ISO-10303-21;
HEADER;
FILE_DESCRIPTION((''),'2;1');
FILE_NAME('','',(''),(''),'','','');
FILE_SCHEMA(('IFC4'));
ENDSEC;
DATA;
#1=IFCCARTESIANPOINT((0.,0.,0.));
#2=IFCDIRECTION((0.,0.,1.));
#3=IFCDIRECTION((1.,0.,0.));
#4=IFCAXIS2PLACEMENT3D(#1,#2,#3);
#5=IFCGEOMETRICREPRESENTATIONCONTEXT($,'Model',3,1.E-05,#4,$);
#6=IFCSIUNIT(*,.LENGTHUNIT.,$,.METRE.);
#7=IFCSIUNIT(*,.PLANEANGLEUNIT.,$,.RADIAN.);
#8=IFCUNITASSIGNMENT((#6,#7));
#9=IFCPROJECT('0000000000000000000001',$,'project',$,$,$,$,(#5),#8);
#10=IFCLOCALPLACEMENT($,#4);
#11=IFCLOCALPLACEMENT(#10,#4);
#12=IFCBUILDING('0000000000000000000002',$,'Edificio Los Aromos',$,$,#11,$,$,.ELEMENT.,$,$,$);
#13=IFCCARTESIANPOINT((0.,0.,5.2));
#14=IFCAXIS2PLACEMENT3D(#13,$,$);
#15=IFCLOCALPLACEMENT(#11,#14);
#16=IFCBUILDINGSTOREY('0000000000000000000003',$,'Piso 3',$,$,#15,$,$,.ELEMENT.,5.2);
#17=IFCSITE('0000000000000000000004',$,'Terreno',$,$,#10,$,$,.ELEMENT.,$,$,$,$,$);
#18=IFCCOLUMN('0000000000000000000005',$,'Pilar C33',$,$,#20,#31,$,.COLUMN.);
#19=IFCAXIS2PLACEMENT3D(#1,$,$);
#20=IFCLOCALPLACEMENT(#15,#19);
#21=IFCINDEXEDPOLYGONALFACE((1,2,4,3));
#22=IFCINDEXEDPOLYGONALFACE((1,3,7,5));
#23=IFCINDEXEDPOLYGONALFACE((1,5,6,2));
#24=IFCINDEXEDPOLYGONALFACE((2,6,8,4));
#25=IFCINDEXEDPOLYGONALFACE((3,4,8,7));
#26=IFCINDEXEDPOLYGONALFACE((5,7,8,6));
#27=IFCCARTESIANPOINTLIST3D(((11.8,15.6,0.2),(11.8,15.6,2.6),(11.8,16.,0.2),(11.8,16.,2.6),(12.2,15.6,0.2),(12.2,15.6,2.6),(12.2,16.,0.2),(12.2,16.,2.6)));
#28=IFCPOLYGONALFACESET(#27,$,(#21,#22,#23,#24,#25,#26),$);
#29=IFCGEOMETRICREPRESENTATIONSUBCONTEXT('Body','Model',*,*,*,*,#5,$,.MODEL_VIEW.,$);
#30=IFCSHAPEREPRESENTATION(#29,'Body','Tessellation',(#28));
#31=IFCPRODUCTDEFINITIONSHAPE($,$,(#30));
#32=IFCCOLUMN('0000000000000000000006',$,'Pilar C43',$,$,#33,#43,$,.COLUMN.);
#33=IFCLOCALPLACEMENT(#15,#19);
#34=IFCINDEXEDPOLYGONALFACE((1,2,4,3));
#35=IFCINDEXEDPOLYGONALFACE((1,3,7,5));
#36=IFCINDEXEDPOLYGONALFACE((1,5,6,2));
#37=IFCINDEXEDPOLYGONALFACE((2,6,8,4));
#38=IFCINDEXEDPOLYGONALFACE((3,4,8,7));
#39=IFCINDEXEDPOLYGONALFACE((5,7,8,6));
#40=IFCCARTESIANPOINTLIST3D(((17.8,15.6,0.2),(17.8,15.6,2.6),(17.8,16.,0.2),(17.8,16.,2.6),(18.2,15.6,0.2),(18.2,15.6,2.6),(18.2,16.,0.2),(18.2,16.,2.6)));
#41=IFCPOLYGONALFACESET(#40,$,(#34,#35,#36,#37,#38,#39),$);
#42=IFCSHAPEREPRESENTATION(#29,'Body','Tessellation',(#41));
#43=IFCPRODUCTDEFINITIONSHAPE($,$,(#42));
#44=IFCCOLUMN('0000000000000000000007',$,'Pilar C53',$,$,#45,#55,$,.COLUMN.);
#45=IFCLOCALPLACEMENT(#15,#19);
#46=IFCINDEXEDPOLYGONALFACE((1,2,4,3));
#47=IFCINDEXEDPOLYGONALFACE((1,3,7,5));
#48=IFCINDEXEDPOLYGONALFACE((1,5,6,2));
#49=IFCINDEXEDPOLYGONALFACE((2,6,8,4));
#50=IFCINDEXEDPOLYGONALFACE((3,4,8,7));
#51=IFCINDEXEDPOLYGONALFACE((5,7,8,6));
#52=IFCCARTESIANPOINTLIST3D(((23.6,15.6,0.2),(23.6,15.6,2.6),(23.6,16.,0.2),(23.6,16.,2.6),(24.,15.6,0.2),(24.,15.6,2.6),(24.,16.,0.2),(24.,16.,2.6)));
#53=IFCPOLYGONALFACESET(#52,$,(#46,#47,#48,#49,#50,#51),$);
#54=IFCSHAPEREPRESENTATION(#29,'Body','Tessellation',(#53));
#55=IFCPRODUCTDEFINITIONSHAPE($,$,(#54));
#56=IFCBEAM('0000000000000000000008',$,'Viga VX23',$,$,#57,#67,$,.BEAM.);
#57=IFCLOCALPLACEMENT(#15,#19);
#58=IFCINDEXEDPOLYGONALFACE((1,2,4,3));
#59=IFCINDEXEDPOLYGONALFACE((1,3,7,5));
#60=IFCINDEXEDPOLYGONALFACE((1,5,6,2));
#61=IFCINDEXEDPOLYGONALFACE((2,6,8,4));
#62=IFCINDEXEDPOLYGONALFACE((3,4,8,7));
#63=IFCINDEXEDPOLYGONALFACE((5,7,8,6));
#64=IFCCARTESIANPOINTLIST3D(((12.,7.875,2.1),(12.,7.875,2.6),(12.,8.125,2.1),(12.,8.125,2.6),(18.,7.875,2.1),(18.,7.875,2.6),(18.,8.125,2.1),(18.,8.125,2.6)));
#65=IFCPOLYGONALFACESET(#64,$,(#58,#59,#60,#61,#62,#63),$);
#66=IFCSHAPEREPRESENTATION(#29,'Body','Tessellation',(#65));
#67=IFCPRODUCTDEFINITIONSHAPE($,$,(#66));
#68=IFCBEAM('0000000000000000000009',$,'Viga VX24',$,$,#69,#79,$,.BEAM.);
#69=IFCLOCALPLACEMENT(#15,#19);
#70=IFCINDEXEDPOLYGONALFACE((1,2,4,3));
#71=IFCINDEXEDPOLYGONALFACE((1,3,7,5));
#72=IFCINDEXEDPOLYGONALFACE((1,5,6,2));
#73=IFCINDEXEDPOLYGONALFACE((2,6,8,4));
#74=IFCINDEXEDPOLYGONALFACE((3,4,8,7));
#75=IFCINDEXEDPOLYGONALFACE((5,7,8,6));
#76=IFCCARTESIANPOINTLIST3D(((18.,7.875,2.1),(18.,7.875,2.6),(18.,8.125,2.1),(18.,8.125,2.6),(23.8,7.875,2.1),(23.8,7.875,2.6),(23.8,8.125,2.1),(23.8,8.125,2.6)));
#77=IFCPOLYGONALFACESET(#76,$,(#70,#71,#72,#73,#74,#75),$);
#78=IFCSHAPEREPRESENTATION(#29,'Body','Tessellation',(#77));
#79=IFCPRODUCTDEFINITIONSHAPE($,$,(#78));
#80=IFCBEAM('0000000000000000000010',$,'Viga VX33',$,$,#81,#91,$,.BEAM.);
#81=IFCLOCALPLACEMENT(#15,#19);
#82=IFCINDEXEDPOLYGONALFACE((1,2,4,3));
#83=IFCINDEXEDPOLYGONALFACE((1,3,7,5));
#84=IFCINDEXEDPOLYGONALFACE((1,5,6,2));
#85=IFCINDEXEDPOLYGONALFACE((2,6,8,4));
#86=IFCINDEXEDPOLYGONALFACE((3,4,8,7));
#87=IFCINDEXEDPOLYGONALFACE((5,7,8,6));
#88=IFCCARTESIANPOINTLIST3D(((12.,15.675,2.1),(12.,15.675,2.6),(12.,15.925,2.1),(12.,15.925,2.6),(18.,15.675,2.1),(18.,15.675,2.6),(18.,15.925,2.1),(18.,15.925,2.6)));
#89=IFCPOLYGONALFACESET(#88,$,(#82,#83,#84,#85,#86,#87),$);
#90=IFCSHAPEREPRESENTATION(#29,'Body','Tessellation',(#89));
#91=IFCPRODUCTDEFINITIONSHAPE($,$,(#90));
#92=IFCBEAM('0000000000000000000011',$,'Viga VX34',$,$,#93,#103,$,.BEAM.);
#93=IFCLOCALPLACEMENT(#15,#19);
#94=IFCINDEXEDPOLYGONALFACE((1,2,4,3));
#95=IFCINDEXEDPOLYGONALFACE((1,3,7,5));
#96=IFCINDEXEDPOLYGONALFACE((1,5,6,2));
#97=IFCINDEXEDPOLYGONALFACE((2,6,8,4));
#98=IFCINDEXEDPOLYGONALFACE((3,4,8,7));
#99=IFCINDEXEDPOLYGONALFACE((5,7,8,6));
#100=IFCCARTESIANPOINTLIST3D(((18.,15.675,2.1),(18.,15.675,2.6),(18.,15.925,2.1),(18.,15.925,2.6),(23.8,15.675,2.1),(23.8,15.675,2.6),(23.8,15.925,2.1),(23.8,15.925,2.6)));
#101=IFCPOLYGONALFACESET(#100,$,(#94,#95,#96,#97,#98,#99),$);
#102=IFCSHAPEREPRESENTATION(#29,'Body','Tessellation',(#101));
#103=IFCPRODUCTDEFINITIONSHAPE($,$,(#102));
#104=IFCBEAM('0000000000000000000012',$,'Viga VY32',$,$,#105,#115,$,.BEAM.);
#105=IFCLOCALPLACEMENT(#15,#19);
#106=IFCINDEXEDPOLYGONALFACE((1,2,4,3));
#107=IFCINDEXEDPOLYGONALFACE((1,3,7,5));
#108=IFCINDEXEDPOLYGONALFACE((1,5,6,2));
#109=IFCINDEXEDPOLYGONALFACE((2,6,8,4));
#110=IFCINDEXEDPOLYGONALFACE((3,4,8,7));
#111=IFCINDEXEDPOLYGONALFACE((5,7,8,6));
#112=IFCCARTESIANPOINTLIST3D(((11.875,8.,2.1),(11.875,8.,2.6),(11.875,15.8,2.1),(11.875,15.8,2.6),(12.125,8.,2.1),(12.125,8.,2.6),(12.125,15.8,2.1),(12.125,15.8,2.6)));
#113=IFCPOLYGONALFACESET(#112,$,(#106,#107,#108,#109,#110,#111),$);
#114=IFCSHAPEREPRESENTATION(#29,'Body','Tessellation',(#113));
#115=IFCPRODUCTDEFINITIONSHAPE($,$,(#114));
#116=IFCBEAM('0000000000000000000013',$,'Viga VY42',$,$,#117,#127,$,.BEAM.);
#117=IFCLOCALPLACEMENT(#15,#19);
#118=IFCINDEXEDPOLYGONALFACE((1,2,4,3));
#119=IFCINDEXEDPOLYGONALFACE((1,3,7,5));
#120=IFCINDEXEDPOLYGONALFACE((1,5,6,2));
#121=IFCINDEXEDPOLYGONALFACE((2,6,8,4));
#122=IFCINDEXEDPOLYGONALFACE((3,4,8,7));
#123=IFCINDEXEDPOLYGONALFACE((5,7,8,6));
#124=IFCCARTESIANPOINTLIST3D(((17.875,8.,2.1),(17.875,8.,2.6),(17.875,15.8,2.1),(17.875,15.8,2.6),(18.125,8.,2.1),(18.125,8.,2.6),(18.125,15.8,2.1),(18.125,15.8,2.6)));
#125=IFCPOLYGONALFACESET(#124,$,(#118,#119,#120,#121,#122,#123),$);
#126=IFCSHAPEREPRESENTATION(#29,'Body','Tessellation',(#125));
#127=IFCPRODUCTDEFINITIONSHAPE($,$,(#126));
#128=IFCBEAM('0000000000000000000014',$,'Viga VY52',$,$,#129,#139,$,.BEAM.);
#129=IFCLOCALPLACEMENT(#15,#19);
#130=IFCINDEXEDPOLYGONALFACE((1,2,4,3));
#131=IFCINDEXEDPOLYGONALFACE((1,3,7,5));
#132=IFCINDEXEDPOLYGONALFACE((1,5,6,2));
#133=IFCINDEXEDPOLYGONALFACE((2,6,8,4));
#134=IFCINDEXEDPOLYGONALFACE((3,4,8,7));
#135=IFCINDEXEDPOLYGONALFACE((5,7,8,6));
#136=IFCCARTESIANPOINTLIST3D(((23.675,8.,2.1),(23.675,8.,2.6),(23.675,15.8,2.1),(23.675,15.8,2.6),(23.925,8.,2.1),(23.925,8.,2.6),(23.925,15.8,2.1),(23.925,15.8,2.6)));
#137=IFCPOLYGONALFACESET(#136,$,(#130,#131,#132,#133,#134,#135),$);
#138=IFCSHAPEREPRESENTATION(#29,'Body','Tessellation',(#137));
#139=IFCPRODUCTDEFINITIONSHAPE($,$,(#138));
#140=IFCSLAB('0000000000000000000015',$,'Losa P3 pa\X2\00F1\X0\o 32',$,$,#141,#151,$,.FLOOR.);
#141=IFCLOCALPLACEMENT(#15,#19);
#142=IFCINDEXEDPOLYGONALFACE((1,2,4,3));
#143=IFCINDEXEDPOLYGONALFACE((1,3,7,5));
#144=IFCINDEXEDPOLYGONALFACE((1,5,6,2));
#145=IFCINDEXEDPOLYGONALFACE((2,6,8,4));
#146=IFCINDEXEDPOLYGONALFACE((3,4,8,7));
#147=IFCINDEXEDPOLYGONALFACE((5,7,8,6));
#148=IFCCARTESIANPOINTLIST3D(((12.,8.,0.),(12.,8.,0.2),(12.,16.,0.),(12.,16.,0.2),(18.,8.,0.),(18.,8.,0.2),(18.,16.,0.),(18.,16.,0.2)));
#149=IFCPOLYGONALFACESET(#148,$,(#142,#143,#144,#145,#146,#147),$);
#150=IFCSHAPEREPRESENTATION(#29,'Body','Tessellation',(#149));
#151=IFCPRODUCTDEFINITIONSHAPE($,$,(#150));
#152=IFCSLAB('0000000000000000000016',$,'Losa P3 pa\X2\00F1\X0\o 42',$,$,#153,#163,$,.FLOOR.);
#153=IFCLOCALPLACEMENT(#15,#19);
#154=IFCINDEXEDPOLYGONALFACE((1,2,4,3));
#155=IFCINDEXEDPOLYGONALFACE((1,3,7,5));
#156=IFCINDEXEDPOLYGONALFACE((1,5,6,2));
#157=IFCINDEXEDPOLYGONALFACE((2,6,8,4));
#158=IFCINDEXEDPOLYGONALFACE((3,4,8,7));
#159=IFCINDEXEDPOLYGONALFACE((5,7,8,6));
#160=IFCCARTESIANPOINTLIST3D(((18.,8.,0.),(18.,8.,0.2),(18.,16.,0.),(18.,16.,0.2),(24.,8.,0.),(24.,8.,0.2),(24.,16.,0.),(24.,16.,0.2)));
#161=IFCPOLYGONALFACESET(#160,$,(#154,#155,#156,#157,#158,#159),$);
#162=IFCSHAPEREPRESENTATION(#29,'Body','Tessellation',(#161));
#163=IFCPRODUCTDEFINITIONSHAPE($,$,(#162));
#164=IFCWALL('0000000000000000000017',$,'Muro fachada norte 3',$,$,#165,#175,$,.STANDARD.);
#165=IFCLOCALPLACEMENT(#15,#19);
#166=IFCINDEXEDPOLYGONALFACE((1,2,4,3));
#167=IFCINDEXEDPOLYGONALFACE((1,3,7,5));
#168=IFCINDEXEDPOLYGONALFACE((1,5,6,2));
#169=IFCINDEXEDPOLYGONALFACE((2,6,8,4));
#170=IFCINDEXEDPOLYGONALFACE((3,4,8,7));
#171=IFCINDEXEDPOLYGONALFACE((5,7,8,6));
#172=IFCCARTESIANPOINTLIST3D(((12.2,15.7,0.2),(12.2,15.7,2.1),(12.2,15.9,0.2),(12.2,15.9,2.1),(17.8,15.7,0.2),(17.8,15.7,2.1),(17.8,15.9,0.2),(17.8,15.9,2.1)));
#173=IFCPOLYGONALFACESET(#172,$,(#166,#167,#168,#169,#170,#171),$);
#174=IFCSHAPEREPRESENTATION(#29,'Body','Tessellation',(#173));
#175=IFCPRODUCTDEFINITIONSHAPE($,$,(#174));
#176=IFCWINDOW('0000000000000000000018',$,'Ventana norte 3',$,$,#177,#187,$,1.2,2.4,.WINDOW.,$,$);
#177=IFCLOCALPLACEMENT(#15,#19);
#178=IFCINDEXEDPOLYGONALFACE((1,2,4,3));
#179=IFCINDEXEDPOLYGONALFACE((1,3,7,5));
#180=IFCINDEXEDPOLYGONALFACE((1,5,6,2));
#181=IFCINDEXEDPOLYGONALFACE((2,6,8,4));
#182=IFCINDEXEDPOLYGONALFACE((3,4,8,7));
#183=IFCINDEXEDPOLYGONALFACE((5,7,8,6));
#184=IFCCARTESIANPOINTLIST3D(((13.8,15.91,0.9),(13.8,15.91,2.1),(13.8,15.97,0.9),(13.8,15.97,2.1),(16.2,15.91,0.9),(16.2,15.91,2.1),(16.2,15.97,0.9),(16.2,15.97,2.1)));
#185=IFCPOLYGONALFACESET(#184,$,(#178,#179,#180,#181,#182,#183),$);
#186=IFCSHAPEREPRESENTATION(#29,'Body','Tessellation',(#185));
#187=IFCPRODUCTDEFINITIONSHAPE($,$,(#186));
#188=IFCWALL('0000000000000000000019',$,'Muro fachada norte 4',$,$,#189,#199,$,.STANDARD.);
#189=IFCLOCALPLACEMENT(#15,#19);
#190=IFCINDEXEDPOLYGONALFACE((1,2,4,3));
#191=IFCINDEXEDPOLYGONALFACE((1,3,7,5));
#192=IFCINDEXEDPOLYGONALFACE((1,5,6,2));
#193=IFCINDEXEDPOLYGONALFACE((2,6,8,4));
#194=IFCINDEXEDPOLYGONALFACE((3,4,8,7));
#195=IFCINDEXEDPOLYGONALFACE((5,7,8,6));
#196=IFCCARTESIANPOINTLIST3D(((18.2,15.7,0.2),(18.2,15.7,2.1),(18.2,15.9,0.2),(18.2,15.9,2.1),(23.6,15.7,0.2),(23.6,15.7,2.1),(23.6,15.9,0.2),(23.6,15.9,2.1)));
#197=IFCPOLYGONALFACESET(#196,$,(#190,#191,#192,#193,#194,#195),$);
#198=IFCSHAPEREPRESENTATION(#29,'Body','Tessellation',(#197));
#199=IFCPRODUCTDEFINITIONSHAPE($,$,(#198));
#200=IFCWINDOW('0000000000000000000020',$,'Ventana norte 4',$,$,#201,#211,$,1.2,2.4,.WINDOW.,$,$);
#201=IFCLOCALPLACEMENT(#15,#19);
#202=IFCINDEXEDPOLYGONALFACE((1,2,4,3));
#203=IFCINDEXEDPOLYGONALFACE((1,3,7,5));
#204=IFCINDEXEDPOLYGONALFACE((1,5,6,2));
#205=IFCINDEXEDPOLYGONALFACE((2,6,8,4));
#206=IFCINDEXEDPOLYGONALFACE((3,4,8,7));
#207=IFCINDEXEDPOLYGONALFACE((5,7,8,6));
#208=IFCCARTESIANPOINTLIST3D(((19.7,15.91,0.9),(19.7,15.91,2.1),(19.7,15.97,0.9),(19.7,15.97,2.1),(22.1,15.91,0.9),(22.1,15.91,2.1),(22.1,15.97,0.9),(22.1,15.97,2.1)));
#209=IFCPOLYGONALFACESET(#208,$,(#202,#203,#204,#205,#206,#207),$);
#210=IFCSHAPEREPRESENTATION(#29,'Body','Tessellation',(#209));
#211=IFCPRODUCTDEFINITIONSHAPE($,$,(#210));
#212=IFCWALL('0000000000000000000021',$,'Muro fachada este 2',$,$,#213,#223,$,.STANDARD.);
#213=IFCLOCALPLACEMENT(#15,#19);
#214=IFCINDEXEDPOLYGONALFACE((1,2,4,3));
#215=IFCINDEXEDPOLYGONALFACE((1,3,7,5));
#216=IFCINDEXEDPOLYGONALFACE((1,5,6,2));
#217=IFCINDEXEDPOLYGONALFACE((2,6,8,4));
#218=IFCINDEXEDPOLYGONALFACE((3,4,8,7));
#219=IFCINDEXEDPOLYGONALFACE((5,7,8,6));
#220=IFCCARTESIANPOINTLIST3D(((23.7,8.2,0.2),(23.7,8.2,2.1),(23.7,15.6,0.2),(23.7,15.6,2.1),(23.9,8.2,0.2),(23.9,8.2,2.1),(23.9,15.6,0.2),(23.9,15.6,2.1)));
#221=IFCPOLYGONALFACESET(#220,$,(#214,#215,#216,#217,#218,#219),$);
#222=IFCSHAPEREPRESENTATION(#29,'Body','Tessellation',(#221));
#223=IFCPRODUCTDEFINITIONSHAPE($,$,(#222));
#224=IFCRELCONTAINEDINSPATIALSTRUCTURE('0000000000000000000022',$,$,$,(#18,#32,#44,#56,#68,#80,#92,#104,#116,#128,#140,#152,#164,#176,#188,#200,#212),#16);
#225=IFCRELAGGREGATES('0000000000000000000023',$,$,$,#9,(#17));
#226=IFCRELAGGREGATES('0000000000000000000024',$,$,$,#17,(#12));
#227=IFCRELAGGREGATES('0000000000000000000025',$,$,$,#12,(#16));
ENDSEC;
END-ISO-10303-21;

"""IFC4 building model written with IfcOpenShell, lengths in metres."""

from ifc_helpers import new_model, si_unit, frame, frame_2d, origin_with_axes, place, context, subcontext, project, spatial, rectangle, extrude, element, save


model = new_model("IFC4")

# Units and contexts
model_context = context("Model", 3, precision=1e-05, world=origin_with_axes())
body_context = subcontext(model_context, "Body", "Model", "MODEL_VIEW")
ifc_project = project(units=[si_unit("LENGTHUNIT", "METRE"), si_unit("PLANEANGLEUNIT", "RADIAN")], contexts=[model_context])

# Site, building, storey
site_placement = place(None, origin_with_axes())
site = spatial("IfcSite", under=ifc_project, at=site_placement, Name="Terreno", CompositionType="ELEMENT")
building_placement = place(site_placement, origin_with_axes())
building = spatial("IfcBuilding", under=site, at=building_placement, Name="Edificio Los Aromos", CompositionType="ELEMENT")
storey_placement = place(building_placement, frame((0.0, 0.0, 5.2)))
storey = spatial("IfcBuildingStorey", under=building, at=storey_placement, Name="Piso 3", CompositionType="ELEMENT", Elevation=5.2)

# Columns
for number, where, name in (
    (1, (11.8, 15.6, 0.2), "Pilar C33"),
    (2, (17.8, 15.6, 0.2), "Pilar C43"),
    (3, (23.6, 15.6, 0.2), "Pilar C53"),
):
    element("IfcColumn", number, at=place(storey_placement, frame(where)), inside=storey, Name=name, PredefinedType="COLUMN", context=body_context, shape_type="SweptSolid", body=[
        extrude(rectangle(XDim=0.4, YDim=0.4, at=frame_2d((0.2, 0.2))), origin_with_axes(), (0.0, 0.0, 1.0), 2.4),
    ])

# Beams
beam_1_placement = place(storey_placement, frame((12.0, 7.875, 2.1)))
element("IfcBeam", 4, at=beam_1_placement, inside=storey, Name="Viga VX23", PredefinedType="BEAM", context=body_context, shape_type="SweptSolid", body=[
    extrude(rectangle(XDim=6.0, YDim=0.25, at=frame_2d((3.0, 0.125))), origin_with_axes(), (0.0, 0.0, 1.0), 0.5),
])
beam_2_placement = place(storey_placement, frame((18.0, 7.875, 2.1)))
element("IfcBeam", 5, at=beam_2_placement, inside=storey, Name="Viga VX24", PredefinedType="BEAM", context=body_context, shape_type="SweptSolid", body=[
    extrude(rectangle(XDim=5.8, YDim=0.25, at=frame_2d((2.9, 0.125))), origin_with_axes(), (0.0, 0.0, 1.0), 0.5),
])
beam_3_placement = place(storey_placement, frame((12.0, 15.675, 2.1)))
element("IfcBeam", 6, at=beam_3_placement, inside=storey, Name="Viga VX33", PredefinedType="BEAM", context=body_context, shape_type="SweptSolid", body=[
    extrude(rectangle(XDim=6.0, YDim=0.25, at=frame_2d((3.0, 0.125))), origin_with_axes(), (0.0, 0.0, 1.0), 0.5),
])
beam_4_placement = place(storey_placement, frame((18.0, 15.675, 2.1)))
element("IfcBeam", 7, at=beam_4_placement, inside=storey, Name="Viga VX34", PredefinedType="BEAM", context=body_context, shape_type="SweptSolid", body=[
    extrude(rectangle(XDim=5.8, YDim=0.25, at=frame_2d((2.9, 0.125))), origin_with_axes(), (0.0, 0.0, 1.0), 0.5),
])
for number, where, name in (
    (8, (11.875, 8.0, 2.1), "Viga VY32"),
    (9, (17.875, 8.0, 2.1), "Viga VY42"),
    (10, (23.675, 8.0, 2.1), "Viga VY52"),
):
    element("IfcBeam", number, at=place(storey_placement, frame(where)), inside=storey, Name=name, PredefinedType="BEAM", context=body_context, shape_type="SweptSolid", body=[
        extrude(rectangle(XDim=0.25, YDim=7.8, at=frame_2d((0.125, 3.9))), origin_with_axes(), (0.0, 0.0, 1.0), 0.5),
    ])

# Slabs
for number, where, name in (
    (11, (12.0, 8.0, 0.0), "Losa P3 paño 32"),
    (12, (18.0, 8.0, 0.0), "Losa P3 paño 42"),
):
    element("IfcSlab", number, at=place(storey_placement, frame(where)), inside=storey, Name=name, PredefinedType="FLOOR", context=body_context, shape_type="SweptSolid", body=[
        extrude(rectangle(XDim=6.0, YDim=8.0, at=frame_2d((3.0, 4.0))), origin_with_axes(), (0.0, 0.0, 1.0), 0.2),
    ])

# Wall
wall_1_placement = place(storey_placement, frame((12.2, 15.7, 0.2)))
element("IfcWall", 13, at=wall_1_placement, inside=storey, Name="Muro fachada norte 3", PredefinedType="STANDARD", context=body_context, shape_type="SweptSolid", body=[
    extrude(rectangle(XDim=5.6, YDim=0.2, at=frame_2d((2.8, 0.1))), origin_with_axes(), (0.0, 0.0, 1.0), 1.9),
])

# Window
window_1_placement = place(storey_placement, frame((13.8, 15.91, 0.9)))
element("IfcWindow", 14, at=window_1_placement, inside=storey, Name="Ventana norte 3", OverallHeight=1.2, OverallWidth=2.4, PredefinedType="WINDOW", context=body_context, shape_type="SweptSolid", body=[
    extrude(rectangle(XDim=2.4, YDim=0.06, at=frame_2d((1.2, 0.03))), origin_with_axes(), (0.0, 0.0, 1.0), 1.2),
])

# Wall
wall_2_placement = place(storey_placement, frame((18.2, 15.7, 0.2)))
element("IfcWall", 15, at=wall_2_placement, inside=storey, Name="Muro fachada norte 4", PredefinedType="STANDARD", context=body_context, shape_type="SweptSolid", body=[
    extrude(rectangle(XDim=5.4, YDim=0.2, at=frame_2d((2.7, 0.1))), origin_with_axes(), (0.0, 0.0, 1.0), 1.9),
])

# Window
window_2_placement = place(storey_placement, frame((19.7, 15.91, 0.9)))
element("IfcWindow", 16, at=window_2_placement, inside=storey, Name="Ventana norte 4", OverallHeight=1.2, OverallWidth=2.4, PredefinedType="WINDOW", context=body_context, shape_type="SweptSolid", body=[
    extrude(rectangle(XDim=2.4, YDim=0.06, at=frame_2d((1.2, 0.03))), origin_with_axes(), (0.0, 0.0, 1.0), 1.2),
])

# Wall
wall_3_placement = place(storey_placement, frame((23.7, 8.2, 0.2)))
element("IfcWall", 17, at=wall_3_placement, inside=storey, Name="Muro fachada este 2", PredefinedType="STANDARD", context=body_context, shape_type="SweptSolid", body=[
    extrude(rectangle(XDim=0.2, YDim=7.4, at=frame_2d((0.1, 3.7))), origin_with_axes(), (0.0, 0.0, 1.0), 1.9),
])

save(model, "model.ifc")
